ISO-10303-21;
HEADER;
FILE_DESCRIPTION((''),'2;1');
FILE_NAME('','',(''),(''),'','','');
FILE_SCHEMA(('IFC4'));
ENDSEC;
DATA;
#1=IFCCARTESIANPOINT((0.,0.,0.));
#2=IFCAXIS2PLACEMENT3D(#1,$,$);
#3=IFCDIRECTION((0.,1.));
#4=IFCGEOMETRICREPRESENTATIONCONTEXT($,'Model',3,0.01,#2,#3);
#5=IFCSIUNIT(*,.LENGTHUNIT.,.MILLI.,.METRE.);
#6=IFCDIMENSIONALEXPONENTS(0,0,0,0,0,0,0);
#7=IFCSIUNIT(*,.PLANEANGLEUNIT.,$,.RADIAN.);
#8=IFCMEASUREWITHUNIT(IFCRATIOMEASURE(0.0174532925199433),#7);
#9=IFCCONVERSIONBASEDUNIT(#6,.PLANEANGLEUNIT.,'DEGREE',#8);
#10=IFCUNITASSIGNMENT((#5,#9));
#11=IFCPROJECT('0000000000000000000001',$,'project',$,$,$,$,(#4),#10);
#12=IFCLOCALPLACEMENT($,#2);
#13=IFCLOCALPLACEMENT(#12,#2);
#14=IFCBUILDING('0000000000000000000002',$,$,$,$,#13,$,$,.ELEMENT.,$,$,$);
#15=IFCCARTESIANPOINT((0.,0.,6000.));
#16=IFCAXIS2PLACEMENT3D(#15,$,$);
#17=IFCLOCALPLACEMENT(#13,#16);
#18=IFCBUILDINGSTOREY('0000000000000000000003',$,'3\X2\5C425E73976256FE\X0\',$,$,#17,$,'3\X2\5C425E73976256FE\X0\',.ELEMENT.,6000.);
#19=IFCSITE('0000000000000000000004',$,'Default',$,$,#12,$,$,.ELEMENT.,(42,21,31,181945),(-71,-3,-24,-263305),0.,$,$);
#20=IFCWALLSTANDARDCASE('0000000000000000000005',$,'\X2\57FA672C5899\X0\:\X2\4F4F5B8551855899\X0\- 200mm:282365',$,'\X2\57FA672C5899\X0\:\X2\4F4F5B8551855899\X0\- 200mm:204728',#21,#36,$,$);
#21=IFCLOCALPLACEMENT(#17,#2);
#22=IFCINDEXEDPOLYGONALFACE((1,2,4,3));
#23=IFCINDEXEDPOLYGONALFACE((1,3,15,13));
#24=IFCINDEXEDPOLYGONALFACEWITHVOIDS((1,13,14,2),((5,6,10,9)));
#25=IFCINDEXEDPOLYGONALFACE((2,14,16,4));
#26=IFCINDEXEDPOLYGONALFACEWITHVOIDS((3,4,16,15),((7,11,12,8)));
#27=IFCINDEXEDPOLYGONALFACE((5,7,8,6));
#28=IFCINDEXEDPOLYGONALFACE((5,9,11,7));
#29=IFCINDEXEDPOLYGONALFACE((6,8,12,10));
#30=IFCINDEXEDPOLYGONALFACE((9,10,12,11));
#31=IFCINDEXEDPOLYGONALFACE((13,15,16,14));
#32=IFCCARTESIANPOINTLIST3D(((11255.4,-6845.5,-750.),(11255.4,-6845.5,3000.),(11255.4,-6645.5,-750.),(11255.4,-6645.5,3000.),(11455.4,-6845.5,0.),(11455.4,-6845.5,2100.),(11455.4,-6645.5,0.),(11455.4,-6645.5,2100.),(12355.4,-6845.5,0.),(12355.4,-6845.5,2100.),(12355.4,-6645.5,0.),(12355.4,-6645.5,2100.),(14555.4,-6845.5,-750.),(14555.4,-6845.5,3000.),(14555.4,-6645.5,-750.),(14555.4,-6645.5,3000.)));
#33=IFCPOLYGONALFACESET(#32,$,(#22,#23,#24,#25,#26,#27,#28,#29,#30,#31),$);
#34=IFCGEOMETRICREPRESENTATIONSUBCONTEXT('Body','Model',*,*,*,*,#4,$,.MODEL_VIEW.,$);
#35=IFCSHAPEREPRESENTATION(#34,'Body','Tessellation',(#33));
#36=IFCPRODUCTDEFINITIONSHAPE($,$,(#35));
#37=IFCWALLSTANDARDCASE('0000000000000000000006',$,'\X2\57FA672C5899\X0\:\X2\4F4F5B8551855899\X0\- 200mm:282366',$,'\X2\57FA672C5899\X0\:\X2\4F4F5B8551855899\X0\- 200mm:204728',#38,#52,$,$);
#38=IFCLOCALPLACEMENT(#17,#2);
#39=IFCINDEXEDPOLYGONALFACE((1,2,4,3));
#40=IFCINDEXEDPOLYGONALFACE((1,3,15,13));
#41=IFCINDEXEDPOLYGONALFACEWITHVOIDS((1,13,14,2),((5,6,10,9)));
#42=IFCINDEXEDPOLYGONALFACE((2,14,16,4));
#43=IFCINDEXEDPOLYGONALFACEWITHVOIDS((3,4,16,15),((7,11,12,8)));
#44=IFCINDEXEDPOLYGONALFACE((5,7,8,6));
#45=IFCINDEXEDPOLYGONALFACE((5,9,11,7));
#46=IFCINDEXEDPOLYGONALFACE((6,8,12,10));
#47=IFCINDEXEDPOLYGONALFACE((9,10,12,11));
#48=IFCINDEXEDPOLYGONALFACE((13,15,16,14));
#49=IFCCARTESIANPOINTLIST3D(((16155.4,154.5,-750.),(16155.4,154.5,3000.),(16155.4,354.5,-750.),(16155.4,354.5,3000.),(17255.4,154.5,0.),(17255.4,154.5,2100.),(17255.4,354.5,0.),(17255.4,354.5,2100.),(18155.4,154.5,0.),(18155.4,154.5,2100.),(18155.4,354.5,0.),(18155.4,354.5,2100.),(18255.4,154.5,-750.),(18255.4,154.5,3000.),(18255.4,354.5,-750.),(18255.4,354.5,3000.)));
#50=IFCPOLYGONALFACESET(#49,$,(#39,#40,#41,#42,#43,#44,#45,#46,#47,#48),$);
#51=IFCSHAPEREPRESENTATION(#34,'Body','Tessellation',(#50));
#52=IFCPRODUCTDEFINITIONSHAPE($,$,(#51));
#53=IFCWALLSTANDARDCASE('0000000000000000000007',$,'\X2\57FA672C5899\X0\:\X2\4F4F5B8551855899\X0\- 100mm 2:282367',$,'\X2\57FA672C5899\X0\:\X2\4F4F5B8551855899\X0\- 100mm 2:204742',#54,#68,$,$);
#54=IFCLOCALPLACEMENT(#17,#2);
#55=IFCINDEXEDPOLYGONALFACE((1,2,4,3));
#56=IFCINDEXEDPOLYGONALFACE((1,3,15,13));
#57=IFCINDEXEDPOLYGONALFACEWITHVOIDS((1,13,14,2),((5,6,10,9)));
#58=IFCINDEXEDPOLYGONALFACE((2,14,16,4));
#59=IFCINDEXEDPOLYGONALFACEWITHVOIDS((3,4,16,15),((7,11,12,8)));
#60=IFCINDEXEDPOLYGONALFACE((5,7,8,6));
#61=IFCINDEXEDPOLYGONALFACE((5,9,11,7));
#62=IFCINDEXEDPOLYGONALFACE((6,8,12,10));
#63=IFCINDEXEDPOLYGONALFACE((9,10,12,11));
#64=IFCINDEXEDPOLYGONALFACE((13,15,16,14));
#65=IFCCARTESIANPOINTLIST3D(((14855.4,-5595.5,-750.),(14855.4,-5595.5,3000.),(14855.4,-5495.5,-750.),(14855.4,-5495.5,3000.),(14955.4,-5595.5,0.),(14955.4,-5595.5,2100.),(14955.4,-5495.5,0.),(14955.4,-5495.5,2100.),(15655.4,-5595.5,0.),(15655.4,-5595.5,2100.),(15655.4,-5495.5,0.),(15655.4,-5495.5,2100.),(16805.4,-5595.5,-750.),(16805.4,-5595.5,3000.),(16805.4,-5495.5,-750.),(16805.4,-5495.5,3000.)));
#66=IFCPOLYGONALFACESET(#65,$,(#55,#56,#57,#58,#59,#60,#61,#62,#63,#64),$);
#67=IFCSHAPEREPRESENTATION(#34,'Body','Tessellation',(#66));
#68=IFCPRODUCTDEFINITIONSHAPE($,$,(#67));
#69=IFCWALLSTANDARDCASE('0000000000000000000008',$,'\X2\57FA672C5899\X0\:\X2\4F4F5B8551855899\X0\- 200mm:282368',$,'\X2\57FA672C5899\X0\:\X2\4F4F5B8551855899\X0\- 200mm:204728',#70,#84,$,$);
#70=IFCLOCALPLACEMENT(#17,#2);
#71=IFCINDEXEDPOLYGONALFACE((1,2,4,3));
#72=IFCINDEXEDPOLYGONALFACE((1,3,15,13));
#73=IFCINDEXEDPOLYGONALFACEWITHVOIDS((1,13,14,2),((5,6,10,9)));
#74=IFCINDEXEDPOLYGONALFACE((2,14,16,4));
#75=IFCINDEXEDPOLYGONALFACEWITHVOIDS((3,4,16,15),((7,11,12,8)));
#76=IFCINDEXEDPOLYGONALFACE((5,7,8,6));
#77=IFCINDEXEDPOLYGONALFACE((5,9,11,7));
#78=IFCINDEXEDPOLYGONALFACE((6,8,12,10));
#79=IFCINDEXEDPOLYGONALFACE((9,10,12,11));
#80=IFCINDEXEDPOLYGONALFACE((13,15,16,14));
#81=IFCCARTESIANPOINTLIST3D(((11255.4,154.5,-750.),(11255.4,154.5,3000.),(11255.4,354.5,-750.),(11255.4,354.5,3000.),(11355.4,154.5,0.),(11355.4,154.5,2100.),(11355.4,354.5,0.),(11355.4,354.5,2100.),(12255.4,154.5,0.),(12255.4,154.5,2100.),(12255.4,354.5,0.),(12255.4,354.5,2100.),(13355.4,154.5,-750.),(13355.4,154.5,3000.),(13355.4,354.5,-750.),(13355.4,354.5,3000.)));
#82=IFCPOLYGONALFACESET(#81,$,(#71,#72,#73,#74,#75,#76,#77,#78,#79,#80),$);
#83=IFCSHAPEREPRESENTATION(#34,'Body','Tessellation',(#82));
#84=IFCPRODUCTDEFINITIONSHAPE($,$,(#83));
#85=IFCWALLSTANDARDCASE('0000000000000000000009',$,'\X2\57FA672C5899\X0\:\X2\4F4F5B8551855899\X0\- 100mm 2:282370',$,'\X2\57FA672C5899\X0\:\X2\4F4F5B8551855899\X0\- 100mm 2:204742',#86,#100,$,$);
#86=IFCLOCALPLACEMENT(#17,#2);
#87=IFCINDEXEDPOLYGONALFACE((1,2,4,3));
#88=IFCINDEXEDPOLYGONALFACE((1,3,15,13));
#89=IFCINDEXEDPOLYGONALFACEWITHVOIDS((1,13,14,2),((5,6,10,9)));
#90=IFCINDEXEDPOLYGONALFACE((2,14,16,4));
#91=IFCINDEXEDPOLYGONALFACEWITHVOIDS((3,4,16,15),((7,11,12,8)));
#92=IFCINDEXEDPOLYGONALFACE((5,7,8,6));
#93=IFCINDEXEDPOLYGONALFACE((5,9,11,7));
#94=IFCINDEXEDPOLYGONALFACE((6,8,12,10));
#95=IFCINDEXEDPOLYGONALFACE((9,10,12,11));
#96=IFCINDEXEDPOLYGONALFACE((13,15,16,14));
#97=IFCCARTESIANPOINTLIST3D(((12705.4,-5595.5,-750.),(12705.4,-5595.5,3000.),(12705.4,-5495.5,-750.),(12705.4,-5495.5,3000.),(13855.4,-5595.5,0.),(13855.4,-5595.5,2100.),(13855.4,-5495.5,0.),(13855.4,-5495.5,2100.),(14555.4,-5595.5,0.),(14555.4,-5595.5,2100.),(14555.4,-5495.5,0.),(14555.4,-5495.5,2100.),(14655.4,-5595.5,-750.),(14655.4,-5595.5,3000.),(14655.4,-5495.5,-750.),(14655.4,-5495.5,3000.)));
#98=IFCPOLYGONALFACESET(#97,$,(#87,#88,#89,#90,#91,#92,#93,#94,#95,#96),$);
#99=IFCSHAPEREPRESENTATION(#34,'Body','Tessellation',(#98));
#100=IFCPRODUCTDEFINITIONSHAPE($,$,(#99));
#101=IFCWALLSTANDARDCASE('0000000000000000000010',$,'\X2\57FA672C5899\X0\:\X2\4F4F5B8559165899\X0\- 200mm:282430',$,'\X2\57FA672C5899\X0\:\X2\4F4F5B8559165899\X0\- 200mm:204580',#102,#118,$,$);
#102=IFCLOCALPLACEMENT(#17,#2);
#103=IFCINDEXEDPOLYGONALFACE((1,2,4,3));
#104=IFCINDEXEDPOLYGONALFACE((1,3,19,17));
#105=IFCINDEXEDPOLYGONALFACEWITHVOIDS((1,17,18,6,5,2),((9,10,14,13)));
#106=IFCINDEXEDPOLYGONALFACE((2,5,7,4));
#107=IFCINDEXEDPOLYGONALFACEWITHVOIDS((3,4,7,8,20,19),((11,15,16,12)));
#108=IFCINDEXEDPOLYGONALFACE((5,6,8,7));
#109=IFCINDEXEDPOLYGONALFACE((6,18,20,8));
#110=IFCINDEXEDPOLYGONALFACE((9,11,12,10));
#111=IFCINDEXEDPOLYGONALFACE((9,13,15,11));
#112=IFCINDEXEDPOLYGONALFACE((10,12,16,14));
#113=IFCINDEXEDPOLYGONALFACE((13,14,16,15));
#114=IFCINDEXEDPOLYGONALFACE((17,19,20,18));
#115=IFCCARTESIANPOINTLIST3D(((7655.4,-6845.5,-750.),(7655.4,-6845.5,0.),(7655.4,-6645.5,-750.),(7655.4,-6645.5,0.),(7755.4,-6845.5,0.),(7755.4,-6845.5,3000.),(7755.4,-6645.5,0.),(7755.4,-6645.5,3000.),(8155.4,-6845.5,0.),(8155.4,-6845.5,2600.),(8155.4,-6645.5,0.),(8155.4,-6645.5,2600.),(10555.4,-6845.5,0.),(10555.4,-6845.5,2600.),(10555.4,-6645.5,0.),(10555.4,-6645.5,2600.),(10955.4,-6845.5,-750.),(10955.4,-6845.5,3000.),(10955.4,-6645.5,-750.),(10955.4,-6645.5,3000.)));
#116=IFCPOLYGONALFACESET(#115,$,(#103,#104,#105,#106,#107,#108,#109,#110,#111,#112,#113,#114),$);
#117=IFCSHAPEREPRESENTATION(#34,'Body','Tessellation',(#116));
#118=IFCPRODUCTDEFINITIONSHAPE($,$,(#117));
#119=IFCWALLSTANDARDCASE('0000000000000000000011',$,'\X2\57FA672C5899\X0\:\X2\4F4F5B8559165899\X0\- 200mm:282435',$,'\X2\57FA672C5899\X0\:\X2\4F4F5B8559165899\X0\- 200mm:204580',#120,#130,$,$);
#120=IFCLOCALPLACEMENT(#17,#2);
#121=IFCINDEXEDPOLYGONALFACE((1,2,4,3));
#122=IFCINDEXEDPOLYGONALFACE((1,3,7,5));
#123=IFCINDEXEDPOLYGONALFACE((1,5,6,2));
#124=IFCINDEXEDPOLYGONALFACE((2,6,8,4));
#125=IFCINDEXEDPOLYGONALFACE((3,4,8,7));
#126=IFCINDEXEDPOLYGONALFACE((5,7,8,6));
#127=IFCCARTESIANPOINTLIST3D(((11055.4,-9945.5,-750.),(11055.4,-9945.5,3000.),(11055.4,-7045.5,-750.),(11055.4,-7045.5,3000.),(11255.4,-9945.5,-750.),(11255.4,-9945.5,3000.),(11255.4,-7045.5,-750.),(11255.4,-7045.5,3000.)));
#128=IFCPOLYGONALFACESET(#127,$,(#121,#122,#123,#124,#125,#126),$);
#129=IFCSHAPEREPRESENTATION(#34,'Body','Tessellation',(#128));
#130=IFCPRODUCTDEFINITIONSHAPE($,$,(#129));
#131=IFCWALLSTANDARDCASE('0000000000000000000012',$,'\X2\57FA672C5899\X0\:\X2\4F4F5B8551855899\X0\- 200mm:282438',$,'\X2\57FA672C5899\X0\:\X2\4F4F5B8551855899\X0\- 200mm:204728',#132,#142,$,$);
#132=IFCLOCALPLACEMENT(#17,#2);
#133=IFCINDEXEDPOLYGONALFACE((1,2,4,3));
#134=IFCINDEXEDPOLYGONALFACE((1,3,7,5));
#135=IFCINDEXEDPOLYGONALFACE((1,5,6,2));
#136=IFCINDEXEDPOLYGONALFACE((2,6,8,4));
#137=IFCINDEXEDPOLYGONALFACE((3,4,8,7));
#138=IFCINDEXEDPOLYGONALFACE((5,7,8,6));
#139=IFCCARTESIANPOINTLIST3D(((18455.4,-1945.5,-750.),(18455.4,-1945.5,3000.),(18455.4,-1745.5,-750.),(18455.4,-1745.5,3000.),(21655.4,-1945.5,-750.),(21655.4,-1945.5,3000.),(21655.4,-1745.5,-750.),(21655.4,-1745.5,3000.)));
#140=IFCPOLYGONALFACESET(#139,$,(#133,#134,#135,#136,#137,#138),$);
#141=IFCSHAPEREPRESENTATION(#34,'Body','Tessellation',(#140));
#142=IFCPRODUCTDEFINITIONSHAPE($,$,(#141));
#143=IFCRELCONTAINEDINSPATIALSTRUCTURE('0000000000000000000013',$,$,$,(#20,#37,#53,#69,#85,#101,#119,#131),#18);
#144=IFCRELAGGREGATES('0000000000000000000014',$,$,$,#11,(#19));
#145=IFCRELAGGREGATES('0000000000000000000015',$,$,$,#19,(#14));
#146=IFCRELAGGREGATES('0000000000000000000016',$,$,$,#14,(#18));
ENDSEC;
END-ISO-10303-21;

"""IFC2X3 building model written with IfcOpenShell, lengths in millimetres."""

from ifc_helpers import new_model, entity, si_unit, converted_unit, direction, frame, frame_2d, origin, place, context, subcontext, project, spatial, polyline, rectangle, extrude, clip, bounded_halfspace, element, save


model = new_model("IFC2X3")

# Units and contexts
model_context = context("Model", 3, precision=0.01, world=origin(), true_north=direction((0.0, 1.0)))
body_context = subcontext(model_context, "Body", "Model", "MODEL_VIEW")
ifc_project = project(units=[si_unit("LENGTHUNIT", "METRE", prefix="MILLI"), converted_unit("PLANEANGLEUNIT", "DEGREE", entity("IfcRatioMeasure", 0.0174532925199433), si_unit("PLANEANGLEUNIT", "RADIAN"), dimensions=[0, 0, 0, 0, 0, 0, 0])], contexts=[model_context])

# Site, building, storey
site_placement = place(None, origin())
site = spatial("IfcSite", under=ifc_project, at=site_placement, Name="Default", CompositionType="ELEMENT", RefLatitude=(42, 21, 31, 181945), RefLongitude=(-71, -3, -24, -263305), RefElevation=0.0)
building_placement = place(site_placement, origin())
building = spatial("IfcBuilding", under=site, at=building_placement, CompositionType="ELEMENT")
storey_placement = place(building_placement, frame((0.0, 0.0, 6000.0)))
storey = spatial("IfcBuildingStorey", under=building, at=storey_placement, Name="3层平面图", LongName="3层平面图", CompositionType="ELEMENT", Elevation=6000.0)

# Walls, openings
wall_1_placement = place(storey_placement, frame((11255.4, -6745.5, -750.0)))
wall_1 = element("IfcWallStandardCase", 1, at=wall_1_placement, inside=storey, Name="基本墙:住宅内墙- 200mm:282365", ObjectType="基本墙:住宅内墙- 200mm:204728", context=body_context, shape_type="Clipping", body=[
    clip(extrude(rectangle(XDim=3300.0, YDim=200.0, at=frame_2d((1650.0, 0.0), x_axis=(-1.0, 0.0))), origin(), (0.0, 0.0, 1.0), 3750.0), bounded_halfspace(frame((3300.0, -100.0, 3750.0), z_axis=(1.0, 0.0, 0.0), x_axis=(0.0, 0.0, -1.0)), False, frame((3300.0, -100.0, 3750.0), z_axis=(1.0, 0.0, 0.0), x_axis=(0.0, 0.0, -1.0)), polyline([(0.0, 0.0), (3750.0, 0.0), (3750.0, 200.0), (0.0, 200.0), (0.0, 0.0)]))),
])
opening_1_placement = place(wall_1_placement, origin())
element("IfcOpeningElement", 2, at=opening_1_placement, cuts=wall_1, ObjectType="Opening", context=body_context, shape_type="SweptSolid", body=[
    extrude(rectangle(XDim=2100.0, YDim=900.0, at=frame_2d((0.0, 0.0), x_axis=(1.0, 0.0))), frame((650.0, -1424.0, 1800.0), z_axis=(0.0, 1.0, 0.0), x_axis=(0.0, 0.0, 1.0)), (0.0, 0.0, 1.0), 3048.0),
])
wall_2_placement = place(storey_placement, frame((18255.4, 254.5, -750.0), z_axis=(0.0, 0.0, 1.0), x_axis=(-1.0, 0.0, 0.0)))
wall_2 = element("IfcWallStandardCase", 3, at=wall_2_placement, inside=storey, Name="基本墙:住宅内墙- 200mm:282366", ObjectType="基本墙:住宅内墙- 200mm:204728", context=body_context, shape_type="SweptSolid", body=[
    extrude(rectangle(XDim=2100.0, YDim=200.0, at=frame_2d((1050.0, 0.0), x_axis=(-1.0, 0.0))), origin(), (0.0, 0.0, 1.0), 3750.0),
])
opening_2_placement = place(wall_2_placement, frame((1000.0, 100.0, 750.0)))
element("IfcOpeningElement", 4, at=opening_2_placement, cuts=wall_2, ObjectType="Opening", context=body_context, shape_type="SweptSolid", body=[
    extrude(rectangle(XDim=2100.0, YDim=900.0, at=frame_2d((1050.0, 450.0), x_axis=(1.0, 0.0))), frame((0.0, 0.0, 0.0), z_axis=(0.0, -1.0, 0.0), x_axis=(0.0, 0.0, 1.0)), (0.0, 0.0, 1.0), 200.0),
])
wall_3_placement = place(storey_placement, frame((16805.4, -5545.5, -750.0), z_axis=(0.0, 0.0, 1.0), x_axis=(-1.0, 0.0, 0.0)))
wall_3 = element("IfcWallStandardCase", 5, at=wall_3_placement, inside=storey, Name="基本墙:住宅内墙- 100mm 2:282367", ObjectType="基本墙:住宅内墙- 100mm 2:204742", context=body_context, shape_type="SweptSolid", body=[
    extrude(rectangle(XDim=1950.0, YDim=100.0, at=frame_2d((975.0, 0.0), x_axis=(-1.0, 0.0))), origin(), (0.0, 0.0, 1.0), 3750.0),
])
opening_3_placement = place(wall_3_placement, origin())
element("IfcOpeningElement", 6, at=opening_3_placement, cuts=wall_3, ObjectType="Opening", context=body_context, shape_type="SweptSolid", body=[
    extrude(rectangle(XDim=2100.0, YDim=700.0, at=frame_2d((0.0, 0.0), x_axis=(0.0, 1.0))), frame((1500.0, -1474.0, 1800.0), z_axis=(0.0, 1.0, 0.0), x_axis=(-1.0, 0.0, 0.0)), (0.0, 0.0, 1.0), 3048.0),
])
wall_4_placement = place(storey_placement, frame((11255.4, 254.5, -750.0)))
wall_4 = element("IfcWallStandardCase", 7, at=wall_4_placement, inside=storey, Name="基本墙:住宅内墙- 200mm:282368", ObjectType="基本墙:住宅内墙- 200mm:204728", context=body_context, shape_type="SweptSolid", body=[
    extrude(rectangle(XDim=2100.0, YDim=200.0, at=frame_2d((1050.0, 0.0), x_axis=(-1.0, 0.0))), origin(), (0.0, 0.0, 1.0), 3750.0),
])
opening_4_placement = place(wall_4_placement, frame((100.0, -100.0, 750.0)))
element("IfcOpeningElement", 8, at=opening_4_placement, cuts=wall_4, ObjectType="Opening", context=body_context, shape_type="SweptSolid", body=[
    extrude(rectangle(XDim=2100.0, YDim=900.0, at=frame_2d((1050.0, 450.0), x_axis=(1.0, 0.0))), frame((0.0, 0.0, 0.0), z_axis=(0.0, 1.0, 0.0), x_axis=(0.0, 0.0, 1.0)), (0.0, 0.0, 1.0), 200.0),
])
wall_5_placement = place(storey_placement, frame((12705.4, -5545.5, -750.0)))
wall_5 = element("IfcWallStandardCase", 9, at=wall_5_placement, inside=storey, Name="基本墙:住宅内墙- 100mm 2:282370", ObjectType="基本墙:住宅内墙- 100mm 2:204742", context=body_context, shape_type="SweptSolid", body=[
    extrude(rectangle(XDim=1950.0, YDim=100.0, at=frame_2d((975.0, 0.0), x_axis=(-1.0, 0.0))), origin(), (0.0, 0.0, 1.0), 3750.0),
])
opening_5_placement = place(wall_5_placement, origin())
element("IfcOpeningElement", 10, at=opening_5_placement, cuts=wall_5, ObjectType="Opening", context=body_context, shape_type="SweptSolid", body=[
    extrude(rectangle(XDim=2100.0, YDim=700.0, at=frame_2d((0.0, 0.0), x_axis=(0.0, 1.0))), frame((1500.0, -1574.0, 1800.0), z_axis=(0.0, 1.0, 0.0), x_axis=(-1.0, 0.0, 0.0)), (0.0, 0.0, 1.0), 3048.0),
])
wall_6_placement = place(storey_placement, frame((7655.4, -6745.5, -750.0)))
wall_6 = element("IfcWallStandardCase", 11, at=wall_6_placement, inside=storey, Name="基本墙:住宅外墙- 200mm:282430", ObjectType="基本墙:住宅外墙- 200mm:204580", context=body_context, shape_type="Clipping", body=[
    clip(clip(clip(extrude(rectangle(XDim=3300.0, YDim=200.0, at=frame_2d((1650.0, 0.0), x_axis=(-1.0, 0.0))), origin(), (0.0, 0.0, 1.0), 3750.0), bounded_halfspace(frame((3300.0, -100.0, 3750.0), z_axis=(-1.0, 0.0, 0.0), x_axis=(0.0, 0.0, -1.0)), True, frame((3300.0, -100.0, 3750.0), z_axis=(-1.0, 0.0, 0.0), x_axis=(0.0, 0.0, -1.0)), polyline([(0.0, 0.0), (0.0, -200.0), (3750.0, -200.0), (3750.0, 0.0), (0.0, 0.0)]))), bounded_halfspace(frame((100.0, -100.0, 750.0), z_axis=(0.0, 0.0, -1.0), x_axis=(1.0, 0.0, 0.0)), True, frame((100.0, -100.0, 750.0), z_axis=(0.0, 0.0, -1.0), x_axis=(1.0, 0.0, 0.0)), polyline([(0.0, 0.0), (-100.0, 0.0), (-100.0, -200.0), (0.0, -200.0), (0.0, 0.0)]))), bounded_halfspace(frame((100.0, 100.0, 750.0), z_axis=(1.0, 0.0, 0.0), x_axis=(0.0, 0.0, -1.0)), True, frame((100.0, 100.0, 750.0), z_axis=(1.0, 0.0, 0.0), x_axis=(0.0, 0.0, -1.0)), polyline([(0.0, 0.0), (-3000.0, 0.0), (-3000.0, -200.0), (0.0, -200.0), (0.0, 0.0)]))),
])
opening_6_placement = place(wall_6_placement, frame((2900.0, 100.0, 750.0)))
element("IfcOpeningElement", 12, at=opening_6_placement, cuts=wall_6, ObjectType="Opening", context=body_context, shape_type="SweptSolid", body=[
    extrude(rectangle(XDim=2600.0, YDim=2400.0, at=frame_2d((1300.0, 1200.0), x_axis=(1.0, 0.0))), frame((0.0, 0.0, 0.0), z_axis=(0.0, -1.0, 0.0), x_axis=(0.0, 0.0, 1.0)), (0.0, 0.0, 1.0), 200.0),
])

# Walls
wall_7_placement = place(storey_placement, frame((11155.4, -7045.5, -750.0), z_axis=(0.0, 0.0, 1.0), x_axis=(0.0, -1.0, 0.0)))
element("IfcWallStandardCase", 13, at=wall_7_placement, inside=storey, Name="基本墙:住宅外墙- 200mm:282435", ObjectType="基本墙:住宅外墙- 200mm:204580", context=body_context, shape_type="Clipping", body=[
    clip(clip(extrude(rectangle(XDim=2900.0, YDim=200.0, at=frame_2d((1450.0, 0.0), x_axis=(-1.0, 0.0))), origin(), (0.0, 0.0, 1.0), 3750.0), bounded_halfspace(frame((0.0, -100.0, 0.0), z_axis=(1.0, 0.0, 0.0), x_axis=(0.0, 0.0, -1.0)), True, frame((0.0, -100.0, 0.0), z_axis=(1.0, 0.0, 0.0), x_axis=(0.0, 0.0, -1.0)), polyline([(0.0, 0.0), (0.0, 200.0), (-3750.0, 200.0), (-3750.0, 0.0), (0.0, 0.0)]))), bounded_halfspace(frame((2900.0, -100.0, 3750.0), z_axis=(-1.0, 0.0, 0.0), x_axis=(0.0, 0.0, -1.0)), True, frame((2900.0, -100.0, 3750.0), z_axis=(-1.0, 0.0, 0.0), x_axis=(0.0, 0.0, -1.0)), polyline([(0.0, 0.0), (0.0, -200.0), (3750.0, -200.0), (3750.0, 0.0), (0.0, 0.0)]))),
])
wall_8_placement = place(storey_placement, frame((21655.4, -1845.5, -750.0), z_axis=(0.0, 0.0, 1.0), x_axis=(-1.0, 0.0, 0.0)))
element("IfcWallStandardCase", 14, at=wall_8_placement, inside=storey, Name="基本墙:住宅内墙- 200mm:282438", ObjectType="基本墙:住宅内墙- 200mm:204728", context=body_context, shape_type="Clipping", body=[
    clip(extrude(rectangle(XDim=3200.0, YDim=200.0, at=frame_2d((1600.0, 0.0), x_axis=(-1.0, 0.0))), origin(), (0.0, 0.0, 1.0), 3750.0), bounded_halfspace(frame((0.0, -100.0, 0.0), z_axis=(-1.0, 0.0, 0.0), x_axis=(0.0, 0.0, -1.0)), False, frame((0.0, -100.0, 0.0), z_axis=(-1.0, 0.0, 0.0), x_axis=(0.0, 0.0, -1.0)), polyline([(0.0, 0.0), (-3750.0, 0.0), (-3750.0, -200.0), (0.0, -200.0), (0.0, 0.0)]))),
])

save(model, "model.ifc")
